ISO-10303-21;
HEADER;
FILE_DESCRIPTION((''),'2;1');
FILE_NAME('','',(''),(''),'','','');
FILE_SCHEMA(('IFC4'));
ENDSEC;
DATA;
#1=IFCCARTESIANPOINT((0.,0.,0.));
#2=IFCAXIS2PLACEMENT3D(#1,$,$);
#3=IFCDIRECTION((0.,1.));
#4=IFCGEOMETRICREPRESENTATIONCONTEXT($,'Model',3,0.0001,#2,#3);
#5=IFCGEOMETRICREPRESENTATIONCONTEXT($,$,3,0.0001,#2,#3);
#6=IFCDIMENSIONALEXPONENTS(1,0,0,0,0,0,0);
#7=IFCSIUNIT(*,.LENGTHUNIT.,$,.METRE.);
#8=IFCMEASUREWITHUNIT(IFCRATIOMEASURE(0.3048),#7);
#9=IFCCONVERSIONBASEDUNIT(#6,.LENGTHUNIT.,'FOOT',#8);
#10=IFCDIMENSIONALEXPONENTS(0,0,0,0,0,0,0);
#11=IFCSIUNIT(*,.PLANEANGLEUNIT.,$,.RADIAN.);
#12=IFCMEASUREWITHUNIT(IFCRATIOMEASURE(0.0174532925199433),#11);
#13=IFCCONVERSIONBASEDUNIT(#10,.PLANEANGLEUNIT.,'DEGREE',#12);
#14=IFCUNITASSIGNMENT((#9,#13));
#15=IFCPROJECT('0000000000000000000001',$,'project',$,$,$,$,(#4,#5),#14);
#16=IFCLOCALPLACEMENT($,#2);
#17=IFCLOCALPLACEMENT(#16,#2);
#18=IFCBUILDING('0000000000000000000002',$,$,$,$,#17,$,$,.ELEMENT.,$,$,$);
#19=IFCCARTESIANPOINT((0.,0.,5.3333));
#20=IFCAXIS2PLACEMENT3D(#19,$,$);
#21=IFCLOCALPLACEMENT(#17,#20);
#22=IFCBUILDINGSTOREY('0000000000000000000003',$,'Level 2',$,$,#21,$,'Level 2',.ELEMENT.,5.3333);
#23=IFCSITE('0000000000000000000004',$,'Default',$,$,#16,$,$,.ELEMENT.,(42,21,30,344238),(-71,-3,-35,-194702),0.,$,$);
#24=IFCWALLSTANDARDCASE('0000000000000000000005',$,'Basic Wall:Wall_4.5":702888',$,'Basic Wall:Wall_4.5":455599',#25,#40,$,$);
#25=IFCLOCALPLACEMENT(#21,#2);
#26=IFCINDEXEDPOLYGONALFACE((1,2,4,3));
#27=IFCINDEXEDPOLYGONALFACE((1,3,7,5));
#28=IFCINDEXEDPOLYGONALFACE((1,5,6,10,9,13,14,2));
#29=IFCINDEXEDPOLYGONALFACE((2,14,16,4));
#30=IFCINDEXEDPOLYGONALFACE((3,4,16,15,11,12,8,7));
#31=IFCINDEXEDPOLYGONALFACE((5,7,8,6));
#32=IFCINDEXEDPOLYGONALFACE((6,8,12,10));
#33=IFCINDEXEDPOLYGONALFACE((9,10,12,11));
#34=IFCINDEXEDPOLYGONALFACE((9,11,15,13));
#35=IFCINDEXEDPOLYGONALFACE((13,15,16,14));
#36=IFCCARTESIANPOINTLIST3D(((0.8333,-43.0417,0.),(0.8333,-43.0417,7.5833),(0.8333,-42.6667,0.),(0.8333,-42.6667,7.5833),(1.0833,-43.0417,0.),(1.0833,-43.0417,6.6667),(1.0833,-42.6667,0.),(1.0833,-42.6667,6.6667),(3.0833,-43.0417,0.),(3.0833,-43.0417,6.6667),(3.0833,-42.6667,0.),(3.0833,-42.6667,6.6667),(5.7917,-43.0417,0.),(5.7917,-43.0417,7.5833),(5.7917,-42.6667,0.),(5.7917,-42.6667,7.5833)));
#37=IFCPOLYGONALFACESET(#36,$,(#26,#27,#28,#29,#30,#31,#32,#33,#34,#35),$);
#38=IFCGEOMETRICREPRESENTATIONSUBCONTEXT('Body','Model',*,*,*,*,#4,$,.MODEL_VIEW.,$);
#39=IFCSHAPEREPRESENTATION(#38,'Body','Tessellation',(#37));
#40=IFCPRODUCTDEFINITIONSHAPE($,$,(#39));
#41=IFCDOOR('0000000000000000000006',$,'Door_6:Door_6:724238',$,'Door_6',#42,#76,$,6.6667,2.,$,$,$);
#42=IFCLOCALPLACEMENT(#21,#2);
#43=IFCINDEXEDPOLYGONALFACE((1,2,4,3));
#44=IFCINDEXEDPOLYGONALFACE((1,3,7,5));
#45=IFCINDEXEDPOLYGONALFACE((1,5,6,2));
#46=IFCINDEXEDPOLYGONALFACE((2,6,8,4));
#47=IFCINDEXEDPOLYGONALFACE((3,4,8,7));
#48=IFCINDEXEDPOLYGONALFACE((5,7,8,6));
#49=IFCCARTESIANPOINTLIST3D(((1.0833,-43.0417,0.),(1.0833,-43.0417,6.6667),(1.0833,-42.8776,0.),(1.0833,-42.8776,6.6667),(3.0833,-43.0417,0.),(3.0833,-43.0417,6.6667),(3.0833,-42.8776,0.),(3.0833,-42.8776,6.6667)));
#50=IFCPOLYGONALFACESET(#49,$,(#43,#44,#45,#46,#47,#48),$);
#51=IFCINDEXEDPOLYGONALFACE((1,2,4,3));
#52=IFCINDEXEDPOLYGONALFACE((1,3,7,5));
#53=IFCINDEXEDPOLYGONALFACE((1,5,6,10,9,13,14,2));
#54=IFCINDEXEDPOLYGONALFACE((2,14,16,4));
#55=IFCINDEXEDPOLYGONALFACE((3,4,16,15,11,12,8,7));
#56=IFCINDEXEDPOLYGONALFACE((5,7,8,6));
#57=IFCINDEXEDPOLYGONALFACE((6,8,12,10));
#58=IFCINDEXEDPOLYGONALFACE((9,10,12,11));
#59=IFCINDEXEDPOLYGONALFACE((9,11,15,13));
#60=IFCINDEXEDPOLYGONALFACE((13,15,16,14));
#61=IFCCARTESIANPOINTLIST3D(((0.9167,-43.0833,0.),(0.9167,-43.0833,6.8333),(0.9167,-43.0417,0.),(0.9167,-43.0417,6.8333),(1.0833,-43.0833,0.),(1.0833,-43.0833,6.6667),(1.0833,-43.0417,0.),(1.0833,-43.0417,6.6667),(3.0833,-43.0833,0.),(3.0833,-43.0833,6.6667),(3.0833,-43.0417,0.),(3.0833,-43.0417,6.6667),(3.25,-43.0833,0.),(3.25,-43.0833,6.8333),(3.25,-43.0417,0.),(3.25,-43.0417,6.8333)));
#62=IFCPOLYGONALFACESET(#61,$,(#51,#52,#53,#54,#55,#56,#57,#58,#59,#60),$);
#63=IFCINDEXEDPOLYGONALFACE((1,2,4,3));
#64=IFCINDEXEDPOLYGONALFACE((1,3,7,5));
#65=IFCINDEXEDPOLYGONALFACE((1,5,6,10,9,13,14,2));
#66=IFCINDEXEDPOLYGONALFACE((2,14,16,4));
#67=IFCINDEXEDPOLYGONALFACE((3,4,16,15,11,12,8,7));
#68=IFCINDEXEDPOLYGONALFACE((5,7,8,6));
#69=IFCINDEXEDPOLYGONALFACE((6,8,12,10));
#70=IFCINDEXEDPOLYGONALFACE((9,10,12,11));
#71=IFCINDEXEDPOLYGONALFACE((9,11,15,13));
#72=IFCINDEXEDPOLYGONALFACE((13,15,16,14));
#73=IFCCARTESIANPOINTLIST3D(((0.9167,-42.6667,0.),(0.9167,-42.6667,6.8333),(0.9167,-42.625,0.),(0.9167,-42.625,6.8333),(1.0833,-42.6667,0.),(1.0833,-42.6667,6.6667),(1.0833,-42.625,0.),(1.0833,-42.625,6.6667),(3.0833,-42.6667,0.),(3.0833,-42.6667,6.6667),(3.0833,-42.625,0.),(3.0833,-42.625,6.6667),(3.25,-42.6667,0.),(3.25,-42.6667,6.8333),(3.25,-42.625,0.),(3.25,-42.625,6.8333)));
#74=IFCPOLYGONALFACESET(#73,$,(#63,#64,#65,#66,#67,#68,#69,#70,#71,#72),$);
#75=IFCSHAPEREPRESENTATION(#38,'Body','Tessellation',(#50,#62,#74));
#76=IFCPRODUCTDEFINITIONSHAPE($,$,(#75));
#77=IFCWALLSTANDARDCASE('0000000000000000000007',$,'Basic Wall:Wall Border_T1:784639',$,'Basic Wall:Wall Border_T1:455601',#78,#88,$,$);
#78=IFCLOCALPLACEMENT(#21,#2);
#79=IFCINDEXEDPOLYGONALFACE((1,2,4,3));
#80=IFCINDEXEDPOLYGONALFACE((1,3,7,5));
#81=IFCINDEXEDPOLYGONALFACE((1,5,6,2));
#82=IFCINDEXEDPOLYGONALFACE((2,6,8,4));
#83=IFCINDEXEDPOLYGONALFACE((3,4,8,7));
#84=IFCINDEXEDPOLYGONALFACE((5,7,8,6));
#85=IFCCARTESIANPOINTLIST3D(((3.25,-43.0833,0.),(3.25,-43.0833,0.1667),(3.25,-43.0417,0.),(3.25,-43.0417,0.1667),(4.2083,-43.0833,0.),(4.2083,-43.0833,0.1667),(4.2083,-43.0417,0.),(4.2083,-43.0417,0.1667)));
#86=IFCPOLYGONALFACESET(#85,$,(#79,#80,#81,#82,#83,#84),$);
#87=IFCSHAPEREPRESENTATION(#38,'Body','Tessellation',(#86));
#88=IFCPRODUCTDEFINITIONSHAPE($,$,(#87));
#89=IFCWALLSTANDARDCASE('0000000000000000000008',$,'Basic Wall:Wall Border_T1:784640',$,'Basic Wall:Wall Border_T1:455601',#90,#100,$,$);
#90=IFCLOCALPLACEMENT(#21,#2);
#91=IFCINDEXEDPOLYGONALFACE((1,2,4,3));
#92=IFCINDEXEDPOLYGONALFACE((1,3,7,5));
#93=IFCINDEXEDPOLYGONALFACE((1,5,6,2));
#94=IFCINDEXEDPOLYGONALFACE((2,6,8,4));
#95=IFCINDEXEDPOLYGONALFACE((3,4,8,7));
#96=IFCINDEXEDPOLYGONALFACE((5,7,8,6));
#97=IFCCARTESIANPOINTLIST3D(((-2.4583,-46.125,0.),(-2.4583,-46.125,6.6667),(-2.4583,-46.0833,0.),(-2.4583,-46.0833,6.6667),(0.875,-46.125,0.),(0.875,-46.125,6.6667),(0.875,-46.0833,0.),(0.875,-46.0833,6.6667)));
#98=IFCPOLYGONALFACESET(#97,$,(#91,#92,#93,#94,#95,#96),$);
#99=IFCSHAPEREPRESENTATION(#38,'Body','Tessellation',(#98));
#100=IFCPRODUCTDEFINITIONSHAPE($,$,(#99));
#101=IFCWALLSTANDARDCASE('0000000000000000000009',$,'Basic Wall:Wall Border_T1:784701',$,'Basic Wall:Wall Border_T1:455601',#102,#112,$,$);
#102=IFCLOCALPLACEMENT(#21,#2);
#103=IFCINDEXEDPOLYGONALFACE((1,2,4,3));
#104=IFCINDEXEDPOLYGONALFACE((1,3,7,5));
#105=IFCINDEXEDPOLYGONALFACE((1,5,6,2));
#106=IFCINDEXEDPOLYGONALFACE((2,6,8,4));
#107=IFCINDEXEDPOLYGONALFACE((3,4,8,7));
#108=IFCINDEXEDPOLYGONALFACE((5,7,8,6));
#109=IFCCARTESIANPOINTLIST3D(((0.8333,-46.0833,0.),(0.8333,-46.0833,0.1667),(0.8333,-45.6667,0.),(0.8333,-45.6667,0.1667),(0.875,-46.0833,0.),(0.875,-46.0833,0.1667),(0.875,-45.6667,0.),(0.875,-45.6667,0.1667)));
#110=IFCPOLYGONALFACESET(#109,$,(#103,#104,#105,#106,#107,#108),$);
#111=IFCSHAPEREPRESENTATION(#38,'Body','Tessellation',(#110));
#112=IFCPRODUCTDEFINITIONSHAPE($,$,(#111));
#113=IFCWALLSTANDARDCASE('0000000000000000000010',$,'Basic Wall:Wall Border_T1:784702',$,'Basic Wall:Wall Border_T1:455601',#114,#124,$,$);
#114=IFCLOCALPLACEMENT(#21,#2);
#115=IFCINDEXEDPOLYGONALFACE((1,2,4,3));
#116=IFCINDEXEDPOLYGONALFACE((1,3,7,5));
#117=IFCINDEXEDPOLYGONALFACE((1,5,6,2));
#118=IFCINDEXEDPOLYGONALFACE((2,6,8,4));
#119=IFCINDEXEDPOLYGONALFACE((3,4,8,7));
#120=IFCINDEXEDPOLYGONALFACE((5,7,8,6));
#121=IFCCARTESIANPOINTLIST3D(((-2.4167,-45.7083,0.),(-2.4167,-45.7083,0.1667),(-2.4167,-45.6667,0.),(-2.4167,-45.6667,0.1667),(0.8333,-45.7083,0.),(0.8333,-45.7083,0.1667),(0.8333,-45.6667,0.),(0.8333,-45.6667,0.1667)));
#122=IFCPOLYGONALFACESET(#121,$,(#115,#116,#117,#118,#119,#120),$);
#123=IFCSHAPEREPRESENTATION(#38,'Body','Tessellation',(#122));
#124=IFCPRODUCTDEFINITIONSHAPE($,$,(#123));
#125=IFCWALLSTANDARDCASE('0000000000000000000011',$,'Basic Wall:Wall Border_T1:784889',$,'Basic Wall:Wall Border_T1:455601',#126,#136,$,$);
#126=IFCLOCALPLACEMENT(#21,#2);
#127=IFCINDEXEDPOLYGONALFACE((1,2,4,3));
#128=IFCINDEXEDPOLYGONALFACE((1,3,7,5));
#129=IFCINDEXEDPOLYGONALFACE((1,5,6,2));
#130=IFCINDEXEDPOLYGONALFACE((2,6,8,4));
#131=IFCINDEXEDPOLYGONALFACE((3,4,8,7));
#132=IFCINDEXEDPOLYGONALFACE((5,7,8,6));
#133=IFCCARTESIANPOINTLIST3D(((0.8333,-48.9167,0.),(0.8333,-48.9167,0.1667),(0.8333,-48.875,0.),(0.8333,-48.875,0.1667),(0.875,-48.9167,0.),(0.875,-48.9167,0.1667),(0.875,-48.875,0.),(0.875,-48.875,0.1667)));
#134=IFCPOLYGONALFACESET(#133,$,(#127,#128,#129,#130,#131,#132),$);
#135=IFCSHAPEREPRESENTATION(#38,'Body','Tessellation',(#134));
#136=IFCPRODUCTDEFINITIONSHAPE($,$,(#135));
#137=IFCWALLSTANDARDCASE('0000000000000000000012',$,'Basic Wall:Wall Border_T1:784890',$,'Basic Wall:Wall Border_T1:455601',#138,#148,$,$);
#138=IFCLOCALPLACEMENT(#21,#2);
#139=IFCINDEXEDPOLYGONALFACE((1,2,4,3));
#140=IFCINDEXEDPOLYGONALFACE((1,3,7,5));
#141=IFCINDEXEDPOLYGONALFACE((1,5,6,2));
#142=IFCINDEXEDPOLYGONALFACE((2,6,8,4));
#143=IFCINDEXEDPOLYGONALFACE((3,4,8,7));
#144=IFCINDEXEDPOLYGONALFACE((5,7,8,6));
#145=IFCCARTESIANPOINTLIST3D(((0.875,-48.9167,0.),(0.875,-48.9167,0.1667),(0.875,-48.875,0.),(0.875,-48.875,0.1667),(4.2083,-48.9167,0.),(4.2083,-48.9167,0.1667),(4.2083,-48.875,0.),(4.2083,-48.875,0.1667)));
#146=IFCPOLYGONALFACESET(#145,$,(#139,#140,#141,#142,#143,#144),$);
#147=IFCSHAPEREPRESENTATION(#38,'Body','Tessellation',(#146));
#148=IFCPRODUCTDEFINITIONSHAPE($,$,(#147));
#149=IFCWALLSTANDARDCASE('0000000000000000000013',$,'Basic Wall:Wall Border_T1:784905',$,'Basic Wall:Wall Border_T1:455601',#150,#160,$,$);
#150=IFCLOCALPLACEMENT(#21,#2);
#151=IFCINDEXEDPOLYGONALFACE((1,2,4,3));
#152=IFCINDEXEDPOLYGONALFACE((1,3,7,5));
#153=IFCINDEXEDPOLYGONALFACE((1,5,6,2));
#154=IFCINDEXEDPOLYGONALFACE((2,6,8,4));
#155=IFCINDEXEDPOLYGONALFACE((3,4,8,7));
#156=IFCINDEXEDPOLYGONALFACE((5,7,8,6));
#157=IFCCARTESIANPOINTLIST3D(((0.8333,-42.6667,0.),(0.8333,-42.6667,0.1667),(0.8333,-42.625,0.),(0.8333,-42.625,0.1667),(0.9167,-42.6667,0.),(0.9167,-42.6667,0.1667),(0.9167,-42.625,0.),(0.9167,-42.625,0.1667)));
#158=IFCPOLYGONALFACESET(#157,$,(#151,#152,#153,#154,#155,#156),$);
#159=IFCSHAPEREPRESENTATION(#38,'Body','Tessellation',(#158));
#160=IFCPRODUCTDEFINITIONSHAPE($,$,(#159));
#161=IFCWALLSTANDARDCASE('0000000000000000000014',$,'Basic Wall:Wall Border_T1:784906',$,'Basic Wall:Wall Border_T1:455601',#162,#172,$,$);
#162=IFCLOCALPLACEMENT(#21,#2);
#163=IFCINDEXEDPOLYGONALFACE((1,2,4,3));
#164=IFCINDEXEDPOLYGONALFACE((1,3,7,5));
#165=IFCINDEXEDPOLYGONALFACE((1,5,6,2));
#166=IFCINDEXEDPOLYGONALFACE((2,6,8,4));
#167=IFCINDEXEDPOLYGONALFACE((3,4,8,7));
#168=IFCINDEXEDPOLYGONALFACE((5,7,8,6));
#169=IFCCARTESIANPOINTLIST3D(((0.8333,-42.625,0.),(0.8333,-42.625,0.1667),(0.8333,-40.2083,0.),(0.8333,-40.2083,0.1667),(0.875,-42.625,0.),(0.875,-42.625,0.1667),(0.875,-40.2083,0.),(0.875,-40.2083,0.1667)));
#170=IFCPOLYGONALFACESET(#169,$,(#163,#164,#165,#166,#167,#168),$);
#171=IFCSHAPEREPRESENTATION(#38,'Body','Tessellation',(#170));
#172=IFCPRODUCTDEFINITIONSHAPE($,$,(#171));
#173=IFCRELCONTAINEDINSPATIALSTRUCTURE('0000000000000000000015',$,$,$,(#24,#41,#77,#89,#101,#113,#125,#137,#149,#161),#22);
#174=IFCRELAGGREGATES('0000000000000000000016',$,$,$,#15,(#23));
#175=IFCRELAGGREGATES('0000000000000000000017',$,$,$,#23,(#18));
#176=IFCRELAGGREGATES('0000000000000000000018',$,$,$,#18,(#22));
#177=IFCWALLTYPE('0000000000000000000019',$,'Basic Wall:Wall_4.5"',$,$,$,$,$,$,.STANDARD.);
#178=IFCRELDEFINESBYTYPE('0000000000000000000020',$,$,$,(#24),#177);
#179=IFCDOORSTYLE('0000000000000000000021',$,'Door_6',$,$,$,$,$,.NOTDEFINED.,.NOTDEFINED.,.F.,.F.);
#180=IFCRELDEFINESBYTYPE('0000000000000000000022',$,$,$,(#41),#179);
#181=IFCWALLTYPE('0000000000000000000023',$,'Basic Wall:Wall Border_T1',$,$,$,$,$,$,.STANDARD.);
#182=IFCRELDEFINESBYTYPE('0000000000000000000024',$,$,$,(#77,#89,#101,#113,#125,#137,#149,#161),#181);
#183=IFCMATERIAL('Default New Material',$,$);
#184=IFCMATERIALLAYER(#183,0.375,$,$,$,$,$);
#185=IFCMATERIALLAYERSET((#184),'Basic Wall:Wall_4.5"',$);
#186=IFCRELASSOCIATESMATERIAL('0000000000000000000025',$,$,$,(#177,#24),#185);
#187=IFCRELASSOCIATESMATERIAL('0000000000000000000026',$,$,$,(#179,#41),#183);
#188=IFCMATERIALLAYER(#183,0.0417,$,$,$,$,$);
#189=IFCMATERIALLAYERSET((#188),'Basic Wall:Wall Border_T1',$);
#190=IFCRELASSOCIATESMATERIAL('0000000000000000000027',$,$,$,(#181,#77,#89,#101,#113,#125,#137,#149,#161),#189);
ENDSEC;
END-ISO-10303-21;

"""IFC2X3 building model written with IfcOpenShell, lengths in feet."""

from ifc_helpers import new_model, entity, si_unit, converted_unit, direction, frame, frame_2d, origin, origin_2d_with_axis, place, context, subcontext, project, spatial, polyline, rectangle, outline, extrude, source, transform, mapped, material, layer, layer_set, layer_usage, type_object, type_shapes, element, fill, save


model = new_model("IFC2X3")

# Units and contexts
model_context = context("Model", 3, precision=0.0001, world=origin(), true_north=direction((0.0, 1.0)))
context_of_model = context(None, 3, precision=0.0001, world=origin(), true_north=direction((0.0, 1.0)))
body_context = subcontext(model_context, "Body", "Model", "MODEL_VIEW")
ifc_project = project(units=[converted_unit("LENGTHUNIT", "FOOT", entity("IfcRatioMeasure", 0.3048), si_unit("LENGTHUNIT", "METRE"), dimensions=[1, 0, 0, 0, 0, 0, 0]), converted_unit("PLANEANGLEUNIT", "DEGREE", entity("IfcRatioMeasure", 0.0174532925199433), si_unit("PLANEANGLEUNIT", "RADIAN"), dimensions=[0, 0, 0, 0, 0, 0, 0])], contexts=[model_context, context_of_model])

# Site, building, storey
site_placement = place(None, origin())
site = spatial("IfcSite", under=ifc_project, at=site_placement, Name="Default", CompositionType="ELEMENT", RefLatitude=(42, 21, 30, 344238), RefLongitude=(-71, -3, -35, -194702), RefElevation=0.0)
building_placement = place(site_placement, origin())
building = spatial("IfcBuilding", under=site, at=building_placement, CompositionType="ELEMENT")
storey_placement = place(building_placement, frame((0.0, 0.0, 5.3333)))
storey = spatial("IfcBuildingStorey", under=building, at=storey_placement, Name="Level 2", LongName="Level 2", CompositionType="ELEMENT", Elevation=5.3333)

# Wall, opening, door
ifc_material = material(Name="Default New Material")
ifc_layer_1 = layer(ifc_material, 0.375)
ifc_layer_set_1 = layer_set([ifc_layer_1], Name="Basic Wall:Wall_4.5\"")
ifc_layer_usage_1 = layer_usage(ifc_layer_set_1, "AXIS2", "NEGATIVE", 0.1875)
wall_type_1 = type_object("IfcWallType", Name="Basic Wall:Wall_4.5\"", PredefinedType="STANDARD", material=ifc_layer_set_1)
wall_1_placement = place(storey_placement, frame((0.8333, -42.8542, 0.0)))
wall_1 = element("IfcWallStandardCase", 1, at=wall_1_placement, inside=storey, type_object=wall_type_1, material=ifc_layer_usage_1, Name="Basic Wall:Wall_4.5\":702888", ObjectType="Basic Wall:Wall_4.5\":455599", context=body_context, shape_type="SweptSolid", body=[
    extrude(rectangle(XDim=4.9583, YDim=0.375, at=frame_2d((2.4792, 0.0), x_axis=(-1.0, 0.0))), origin(), (0.0, 0.0, 1.0), 7.5833),
])
opening_placement = place(wall_1_placement, frame((2.25, 0.1875, 0.0)))
opening = element("IfcOpeningElement", 2, at=opening_placement, cuts=wall_1, ObjectType="Opening", context=body_context, shape_type="SweptSolid", body=[
    extrude(rectangle(XDim=2.0, YDim=6.6667, at=frame_2d((3.3333, 1.0), x_axis=(0.0, 1.0))), frame((0.0, 0.0, 0.0), z_axis=(0.0, -1.0, 0.0), x_axis=(0.0, 0.0, 1.0)), (0.0, 0.0, 1.0), 0.375),
])
door_style = type_object("IfcDoorStyle", Name="Door_6", ConstructionType="NOTDEFINED", OperationType="NOTDEFINED", ParameterTakesPrecedence=False, Sizeable=False, material=ifc_material)
shared_shape_1 = source(origin(), body_context, "Body", "SweptSolid", [
    extrude(rectangle(XDim=0.164, YDim=2.0, at=origin_2d_with_axis()), frame((1.0, 0.293, 0.0), z_axis=(0.0, 0.0, 1.0), x_axis=(0.0, 1.0, 0.0)), (0.0, 0.0, 1.0), 6.6667),
    extrude(outline(polyline([(-1.1667, -3.4583), (1.1667, -3.4583), (1.1667, 3.375), (1.0, 3.375), (1.0, -3.2917), (-1.0, -3.2917), (-1.0, 3.375), (-1.1667, 3.375), (-1.1667, -3.4583)])), frame((1.0, 0.375, 3.375), z_axis=(0.0, 1.0, 0.0), x_axis=(1.0, 0.0, 0.0)), (0.0, 0.0, 1.0), 0.0417),
    extrude(outline(polyline([(-3.4583, -1.1667), (3.375, -1.1667), (3.375, -1.0), (-3.2917, -1.0), (-3.2917, 1.0), (3.375, 1.0), (3.375, 1.1667), (-3.4583, 1.1667), (-3.4583, -1.1667)])), frame((1.0, -0.0417, 3.375), z_axis=(0.0, 1.0, 0.0), x_axis=(0.0, 0.0, -1.0)), (0.0, 0.0, 1.0), 0.0417),
])
type_shapes(door_style, [shared_shape_1])
door_placement = place(opening_placement, frame((0.0, 0.0, 0.0), z_axis=(0.0, 0.0, 1.0), x_axis=(-1.0, 0.0, 0.0)))
door = element("IfcDoor", 3, at=door_placement, inside=storey, type_object=door_style, material=ifc_material, Name="Door_6:Door_6:724238", ObjectType="Door_6", OverallHeight=6.6667, OverallWidth=2.0, context=body_context, shape_type="MappedRepresentation", body=[
    mapped(shared_shape_1, transform((0.0, 0.0, 0.0), scale=1.0)),
])
fill(opening, door)

# Walls
ifc_layer_2 = layer(ifc_material, 0.0417)
ifc_layer_set_2 = layer_set([ifc_layer_2], Name="Basic Wall:Wall Border_T1")
ifc_layer_usage_2 = layer_usage(ifc_layer_set_2, "AXIS2", "POSITIVE", -0.0208)
wall_type_2 = type_object("IfcWallType", Name="Basic Wall:Wall Border_T1", PredefinedType="STANDARD", material=ifc_layer_set_2)
wall_2_placement = place(storey_placement, frame((3.25, -43.0625, 0.0)))
element("IfcWallStandardCase", 4, at=wall_2_placement, inside=storey, type_object=wall_type_2, material=ifc_layer_usage_2, Name="Basic Wall:Wall Border_T1:784639", ObjectType="Basic Wall:Wall Border_T1:455601", context=body_context, shape_type="SweptSolid", body=[
    extrude(rectangle(XDim=0.9583, YDim=0.0417, at=frame_2d((0.4792, 0.0), x_axis=(-1.0, 0.0))), origin(), (0.0, 0.0, 1.0), 0.1667),
])
ifc_layer_usage_3 = layer_usage(ifc_layer_set_2, "AXIS2", "NEGATIVE", 0.0208)
wall_3_placement = place(storey_placement, frame((0.875, -46.1042, 0.0), z_axis=(0.0, 0.0, 1.0), x_axis=(-1.0, 0.0, 0.0)))
element("IfcWallStandardCase", 5, at=wall_3_placement, inside=storey, type_object=wall_type_2, material=ifc_layer_usage_3, Name="Basic Wall:Wall Border_T1:784640", ObjectType="Basic Wall:Wall Border_T1:455601", context=body_context, shape_type="SweptSolid", body=[
    extrude(rectangle(XDim=3.3333, YDim=0.0417, at=frame_2d((1.6667, 0.0), x_axis=(-1.0, 0.0))), origin(), (0.0, 0.0, 1.0), 6.6667),
])
ifc_layer_usage_4 = layer_usage(ifc_layer_set_2, "AXIS2", "POSITIVE", -0.0208)
wall_4_placement = place(storey_placement, frame((0.8542, -46.0833, 0.0), z_axis=(0.0, 0.0, 1.0), x_axis=(0.0, 1.0, 0.0)))
element("IfcWallStandardCase", 6, at=wall_4_placement, inside=storey, type_object=wall_type_2, material=ifc_layer_usage_4, Name="Basic Wall:Wall Border_T1:784701", ObjectType="Basic Wall:Wall Border_T1:455601", context=body_context, shape_type="SweptSolid", body=[
    extrude(rectangle(XDim=0.4167, YDim=0.0417, at=frame_2d((0.2083, 0.0), x_axis=(-1.0, 0.0))), origin(), (0.0, 0.0, 1.0), 0.1667),
])
ifc_layer_usage_5 = layer_usage(ifc_layer_set_2, "AXIS2", "POSITIVE", -0.0208)
wall_5_placement = place(storey_placement, frame((0.8333, -45.6875, 0.0), z_axis=(0.0, 0.0, 1.0), x_axis=(-1.0, 0.0, 0.0)))
element("IfcWallStandardCase", 7, at=wall_5_placement, inside=storey, type_object=wall_type_2, material=ifc_layer_usage_5, Name="Basic Wall:Wall Border_T1:784702", ObjectType="Basic Wall:Wall Border_T1:455601", context=body_context, shape_type="SweptSolid", body=[
    extrude(rectangle(XDim=3.25, YDim=0.0417, at=frame_2d((1.625, 0.0), x_axis=(-1.0, 0.0))), origin(), (0.0, 0.0, 1.0), 0.1667),
])
ifc_layer_usage_6 = layer_usage(ifc_layer_set_2, "AXIS2", "NEGATIVE", 0.0208)
wall_6_placement = place(storey_placement, frame((0.8542, -48.875, 0.0), z_axis=(0.0, 0.0, 1.0), x_axis=(0.0, -1.0, 0.0)))
element("IfcWallStandardCase", 8, at=wall_6_placement, inside=storey, type_object=wall_type_2, material=ifc_layer_usage_6, Name="Basic Wall:Wall Border_T1:784889", ObjectType="Basic Wall:Wall Border_T1:455601", context=body_context, shape_type="SweptSolid", body=[
    extrude(rectangle(XDim=0.0417, YDim=0.0417, at=frame_2d((0.0208, 0.0), x_axis=(-1.0, 0.0))), origin(), (0.0, 0.0, 1.0), 0.1667),
])
ifc_layer_usage_7 = layer_usage(ifc_layer_set_2, "AXIS2", "NEGATIVE", 0.0208)
wall_7_placement = place(storey_placement, frame((0.875, -48.8958, 0.0)))
element("IfcWallStandardCase", 9, at=wall_7_placement, inside=storey, type_object=wall_type_2, material=ifc_layer_usage_7, Name="Basic Wall:Wall Border_T1:784890", ObjectType="Basic Wall:Wall Border_T1:455601", context=body_context, shape_type="SweptSolid", body=[
    extrude(rectangle(XDim=3.3333, YDim=0.0417, at=frame_2d((1.6667, 0.0), x_axis=(-1.0, 0.0))), origin(), (0.0, 0.0, 1.0), 0.1667),
])
ifc_layer_usage_8 = layer_usage(ifc_layer_set_2, "AXIS2", "POSITIVE", -0.0208)
wall_8_placement = place(storey_placement, frame((0.9167, -42.6458, 0.0), z_axis=(0.0, 0.0, 1.0), x_axis=(-1.0, 0.0, 0.0)))
element("IfcWallStandardCase", 10, at=wall_8_placement, inside=storey, type_object=wall_type_2, material=ifc_layer_usage_8, Name="Basic Wall:Wall Border_T1:784905", ObjectType="Basic Wall:Wall Border_T1:455601", context=body_context, shape_type="SweptSolid", body=[
    extrude(rectangle(XDim=0.0833, YDim=0.0417, at=frame_2d((0.0417, 0.0), x_axis=(-1.0, 0.0))), origin(), (0.0, 0.0, 1.0), 0.1667),
])
ifc_layer_usage_9 = layer_usage(ifc_layer_set_2, "AXIS2", "POSITIVE", -0.0208)
wall_9_placement = place(storey_placement, frame((0.8542, -42.625, 0.0), z_axis=(0.0, 0.0, 1.0), x_axis=(0.0, 1.0, 0.0)))
element("IfcWallStandardCase", 11, at=wall_9_placement, inside=storey, type_object=wall_type_2, material=ifc_layer_usage_9, Name="Basic Wall:Wall Border_T1:784906", ObjectType="Basic Wall:Wall Border_T1:455601", context=body_context, shape_type="SweptSolid", body=[
    extrude(rectangle(XDim=2.4167, YDim=0.0417, at=frame_2d((1.2083, 0.0), x_axis=(-1.0, 0.0))), origin(), (0.0, 0.0, 1.0), 0.1667),
])

save(model, "model.ifc")
